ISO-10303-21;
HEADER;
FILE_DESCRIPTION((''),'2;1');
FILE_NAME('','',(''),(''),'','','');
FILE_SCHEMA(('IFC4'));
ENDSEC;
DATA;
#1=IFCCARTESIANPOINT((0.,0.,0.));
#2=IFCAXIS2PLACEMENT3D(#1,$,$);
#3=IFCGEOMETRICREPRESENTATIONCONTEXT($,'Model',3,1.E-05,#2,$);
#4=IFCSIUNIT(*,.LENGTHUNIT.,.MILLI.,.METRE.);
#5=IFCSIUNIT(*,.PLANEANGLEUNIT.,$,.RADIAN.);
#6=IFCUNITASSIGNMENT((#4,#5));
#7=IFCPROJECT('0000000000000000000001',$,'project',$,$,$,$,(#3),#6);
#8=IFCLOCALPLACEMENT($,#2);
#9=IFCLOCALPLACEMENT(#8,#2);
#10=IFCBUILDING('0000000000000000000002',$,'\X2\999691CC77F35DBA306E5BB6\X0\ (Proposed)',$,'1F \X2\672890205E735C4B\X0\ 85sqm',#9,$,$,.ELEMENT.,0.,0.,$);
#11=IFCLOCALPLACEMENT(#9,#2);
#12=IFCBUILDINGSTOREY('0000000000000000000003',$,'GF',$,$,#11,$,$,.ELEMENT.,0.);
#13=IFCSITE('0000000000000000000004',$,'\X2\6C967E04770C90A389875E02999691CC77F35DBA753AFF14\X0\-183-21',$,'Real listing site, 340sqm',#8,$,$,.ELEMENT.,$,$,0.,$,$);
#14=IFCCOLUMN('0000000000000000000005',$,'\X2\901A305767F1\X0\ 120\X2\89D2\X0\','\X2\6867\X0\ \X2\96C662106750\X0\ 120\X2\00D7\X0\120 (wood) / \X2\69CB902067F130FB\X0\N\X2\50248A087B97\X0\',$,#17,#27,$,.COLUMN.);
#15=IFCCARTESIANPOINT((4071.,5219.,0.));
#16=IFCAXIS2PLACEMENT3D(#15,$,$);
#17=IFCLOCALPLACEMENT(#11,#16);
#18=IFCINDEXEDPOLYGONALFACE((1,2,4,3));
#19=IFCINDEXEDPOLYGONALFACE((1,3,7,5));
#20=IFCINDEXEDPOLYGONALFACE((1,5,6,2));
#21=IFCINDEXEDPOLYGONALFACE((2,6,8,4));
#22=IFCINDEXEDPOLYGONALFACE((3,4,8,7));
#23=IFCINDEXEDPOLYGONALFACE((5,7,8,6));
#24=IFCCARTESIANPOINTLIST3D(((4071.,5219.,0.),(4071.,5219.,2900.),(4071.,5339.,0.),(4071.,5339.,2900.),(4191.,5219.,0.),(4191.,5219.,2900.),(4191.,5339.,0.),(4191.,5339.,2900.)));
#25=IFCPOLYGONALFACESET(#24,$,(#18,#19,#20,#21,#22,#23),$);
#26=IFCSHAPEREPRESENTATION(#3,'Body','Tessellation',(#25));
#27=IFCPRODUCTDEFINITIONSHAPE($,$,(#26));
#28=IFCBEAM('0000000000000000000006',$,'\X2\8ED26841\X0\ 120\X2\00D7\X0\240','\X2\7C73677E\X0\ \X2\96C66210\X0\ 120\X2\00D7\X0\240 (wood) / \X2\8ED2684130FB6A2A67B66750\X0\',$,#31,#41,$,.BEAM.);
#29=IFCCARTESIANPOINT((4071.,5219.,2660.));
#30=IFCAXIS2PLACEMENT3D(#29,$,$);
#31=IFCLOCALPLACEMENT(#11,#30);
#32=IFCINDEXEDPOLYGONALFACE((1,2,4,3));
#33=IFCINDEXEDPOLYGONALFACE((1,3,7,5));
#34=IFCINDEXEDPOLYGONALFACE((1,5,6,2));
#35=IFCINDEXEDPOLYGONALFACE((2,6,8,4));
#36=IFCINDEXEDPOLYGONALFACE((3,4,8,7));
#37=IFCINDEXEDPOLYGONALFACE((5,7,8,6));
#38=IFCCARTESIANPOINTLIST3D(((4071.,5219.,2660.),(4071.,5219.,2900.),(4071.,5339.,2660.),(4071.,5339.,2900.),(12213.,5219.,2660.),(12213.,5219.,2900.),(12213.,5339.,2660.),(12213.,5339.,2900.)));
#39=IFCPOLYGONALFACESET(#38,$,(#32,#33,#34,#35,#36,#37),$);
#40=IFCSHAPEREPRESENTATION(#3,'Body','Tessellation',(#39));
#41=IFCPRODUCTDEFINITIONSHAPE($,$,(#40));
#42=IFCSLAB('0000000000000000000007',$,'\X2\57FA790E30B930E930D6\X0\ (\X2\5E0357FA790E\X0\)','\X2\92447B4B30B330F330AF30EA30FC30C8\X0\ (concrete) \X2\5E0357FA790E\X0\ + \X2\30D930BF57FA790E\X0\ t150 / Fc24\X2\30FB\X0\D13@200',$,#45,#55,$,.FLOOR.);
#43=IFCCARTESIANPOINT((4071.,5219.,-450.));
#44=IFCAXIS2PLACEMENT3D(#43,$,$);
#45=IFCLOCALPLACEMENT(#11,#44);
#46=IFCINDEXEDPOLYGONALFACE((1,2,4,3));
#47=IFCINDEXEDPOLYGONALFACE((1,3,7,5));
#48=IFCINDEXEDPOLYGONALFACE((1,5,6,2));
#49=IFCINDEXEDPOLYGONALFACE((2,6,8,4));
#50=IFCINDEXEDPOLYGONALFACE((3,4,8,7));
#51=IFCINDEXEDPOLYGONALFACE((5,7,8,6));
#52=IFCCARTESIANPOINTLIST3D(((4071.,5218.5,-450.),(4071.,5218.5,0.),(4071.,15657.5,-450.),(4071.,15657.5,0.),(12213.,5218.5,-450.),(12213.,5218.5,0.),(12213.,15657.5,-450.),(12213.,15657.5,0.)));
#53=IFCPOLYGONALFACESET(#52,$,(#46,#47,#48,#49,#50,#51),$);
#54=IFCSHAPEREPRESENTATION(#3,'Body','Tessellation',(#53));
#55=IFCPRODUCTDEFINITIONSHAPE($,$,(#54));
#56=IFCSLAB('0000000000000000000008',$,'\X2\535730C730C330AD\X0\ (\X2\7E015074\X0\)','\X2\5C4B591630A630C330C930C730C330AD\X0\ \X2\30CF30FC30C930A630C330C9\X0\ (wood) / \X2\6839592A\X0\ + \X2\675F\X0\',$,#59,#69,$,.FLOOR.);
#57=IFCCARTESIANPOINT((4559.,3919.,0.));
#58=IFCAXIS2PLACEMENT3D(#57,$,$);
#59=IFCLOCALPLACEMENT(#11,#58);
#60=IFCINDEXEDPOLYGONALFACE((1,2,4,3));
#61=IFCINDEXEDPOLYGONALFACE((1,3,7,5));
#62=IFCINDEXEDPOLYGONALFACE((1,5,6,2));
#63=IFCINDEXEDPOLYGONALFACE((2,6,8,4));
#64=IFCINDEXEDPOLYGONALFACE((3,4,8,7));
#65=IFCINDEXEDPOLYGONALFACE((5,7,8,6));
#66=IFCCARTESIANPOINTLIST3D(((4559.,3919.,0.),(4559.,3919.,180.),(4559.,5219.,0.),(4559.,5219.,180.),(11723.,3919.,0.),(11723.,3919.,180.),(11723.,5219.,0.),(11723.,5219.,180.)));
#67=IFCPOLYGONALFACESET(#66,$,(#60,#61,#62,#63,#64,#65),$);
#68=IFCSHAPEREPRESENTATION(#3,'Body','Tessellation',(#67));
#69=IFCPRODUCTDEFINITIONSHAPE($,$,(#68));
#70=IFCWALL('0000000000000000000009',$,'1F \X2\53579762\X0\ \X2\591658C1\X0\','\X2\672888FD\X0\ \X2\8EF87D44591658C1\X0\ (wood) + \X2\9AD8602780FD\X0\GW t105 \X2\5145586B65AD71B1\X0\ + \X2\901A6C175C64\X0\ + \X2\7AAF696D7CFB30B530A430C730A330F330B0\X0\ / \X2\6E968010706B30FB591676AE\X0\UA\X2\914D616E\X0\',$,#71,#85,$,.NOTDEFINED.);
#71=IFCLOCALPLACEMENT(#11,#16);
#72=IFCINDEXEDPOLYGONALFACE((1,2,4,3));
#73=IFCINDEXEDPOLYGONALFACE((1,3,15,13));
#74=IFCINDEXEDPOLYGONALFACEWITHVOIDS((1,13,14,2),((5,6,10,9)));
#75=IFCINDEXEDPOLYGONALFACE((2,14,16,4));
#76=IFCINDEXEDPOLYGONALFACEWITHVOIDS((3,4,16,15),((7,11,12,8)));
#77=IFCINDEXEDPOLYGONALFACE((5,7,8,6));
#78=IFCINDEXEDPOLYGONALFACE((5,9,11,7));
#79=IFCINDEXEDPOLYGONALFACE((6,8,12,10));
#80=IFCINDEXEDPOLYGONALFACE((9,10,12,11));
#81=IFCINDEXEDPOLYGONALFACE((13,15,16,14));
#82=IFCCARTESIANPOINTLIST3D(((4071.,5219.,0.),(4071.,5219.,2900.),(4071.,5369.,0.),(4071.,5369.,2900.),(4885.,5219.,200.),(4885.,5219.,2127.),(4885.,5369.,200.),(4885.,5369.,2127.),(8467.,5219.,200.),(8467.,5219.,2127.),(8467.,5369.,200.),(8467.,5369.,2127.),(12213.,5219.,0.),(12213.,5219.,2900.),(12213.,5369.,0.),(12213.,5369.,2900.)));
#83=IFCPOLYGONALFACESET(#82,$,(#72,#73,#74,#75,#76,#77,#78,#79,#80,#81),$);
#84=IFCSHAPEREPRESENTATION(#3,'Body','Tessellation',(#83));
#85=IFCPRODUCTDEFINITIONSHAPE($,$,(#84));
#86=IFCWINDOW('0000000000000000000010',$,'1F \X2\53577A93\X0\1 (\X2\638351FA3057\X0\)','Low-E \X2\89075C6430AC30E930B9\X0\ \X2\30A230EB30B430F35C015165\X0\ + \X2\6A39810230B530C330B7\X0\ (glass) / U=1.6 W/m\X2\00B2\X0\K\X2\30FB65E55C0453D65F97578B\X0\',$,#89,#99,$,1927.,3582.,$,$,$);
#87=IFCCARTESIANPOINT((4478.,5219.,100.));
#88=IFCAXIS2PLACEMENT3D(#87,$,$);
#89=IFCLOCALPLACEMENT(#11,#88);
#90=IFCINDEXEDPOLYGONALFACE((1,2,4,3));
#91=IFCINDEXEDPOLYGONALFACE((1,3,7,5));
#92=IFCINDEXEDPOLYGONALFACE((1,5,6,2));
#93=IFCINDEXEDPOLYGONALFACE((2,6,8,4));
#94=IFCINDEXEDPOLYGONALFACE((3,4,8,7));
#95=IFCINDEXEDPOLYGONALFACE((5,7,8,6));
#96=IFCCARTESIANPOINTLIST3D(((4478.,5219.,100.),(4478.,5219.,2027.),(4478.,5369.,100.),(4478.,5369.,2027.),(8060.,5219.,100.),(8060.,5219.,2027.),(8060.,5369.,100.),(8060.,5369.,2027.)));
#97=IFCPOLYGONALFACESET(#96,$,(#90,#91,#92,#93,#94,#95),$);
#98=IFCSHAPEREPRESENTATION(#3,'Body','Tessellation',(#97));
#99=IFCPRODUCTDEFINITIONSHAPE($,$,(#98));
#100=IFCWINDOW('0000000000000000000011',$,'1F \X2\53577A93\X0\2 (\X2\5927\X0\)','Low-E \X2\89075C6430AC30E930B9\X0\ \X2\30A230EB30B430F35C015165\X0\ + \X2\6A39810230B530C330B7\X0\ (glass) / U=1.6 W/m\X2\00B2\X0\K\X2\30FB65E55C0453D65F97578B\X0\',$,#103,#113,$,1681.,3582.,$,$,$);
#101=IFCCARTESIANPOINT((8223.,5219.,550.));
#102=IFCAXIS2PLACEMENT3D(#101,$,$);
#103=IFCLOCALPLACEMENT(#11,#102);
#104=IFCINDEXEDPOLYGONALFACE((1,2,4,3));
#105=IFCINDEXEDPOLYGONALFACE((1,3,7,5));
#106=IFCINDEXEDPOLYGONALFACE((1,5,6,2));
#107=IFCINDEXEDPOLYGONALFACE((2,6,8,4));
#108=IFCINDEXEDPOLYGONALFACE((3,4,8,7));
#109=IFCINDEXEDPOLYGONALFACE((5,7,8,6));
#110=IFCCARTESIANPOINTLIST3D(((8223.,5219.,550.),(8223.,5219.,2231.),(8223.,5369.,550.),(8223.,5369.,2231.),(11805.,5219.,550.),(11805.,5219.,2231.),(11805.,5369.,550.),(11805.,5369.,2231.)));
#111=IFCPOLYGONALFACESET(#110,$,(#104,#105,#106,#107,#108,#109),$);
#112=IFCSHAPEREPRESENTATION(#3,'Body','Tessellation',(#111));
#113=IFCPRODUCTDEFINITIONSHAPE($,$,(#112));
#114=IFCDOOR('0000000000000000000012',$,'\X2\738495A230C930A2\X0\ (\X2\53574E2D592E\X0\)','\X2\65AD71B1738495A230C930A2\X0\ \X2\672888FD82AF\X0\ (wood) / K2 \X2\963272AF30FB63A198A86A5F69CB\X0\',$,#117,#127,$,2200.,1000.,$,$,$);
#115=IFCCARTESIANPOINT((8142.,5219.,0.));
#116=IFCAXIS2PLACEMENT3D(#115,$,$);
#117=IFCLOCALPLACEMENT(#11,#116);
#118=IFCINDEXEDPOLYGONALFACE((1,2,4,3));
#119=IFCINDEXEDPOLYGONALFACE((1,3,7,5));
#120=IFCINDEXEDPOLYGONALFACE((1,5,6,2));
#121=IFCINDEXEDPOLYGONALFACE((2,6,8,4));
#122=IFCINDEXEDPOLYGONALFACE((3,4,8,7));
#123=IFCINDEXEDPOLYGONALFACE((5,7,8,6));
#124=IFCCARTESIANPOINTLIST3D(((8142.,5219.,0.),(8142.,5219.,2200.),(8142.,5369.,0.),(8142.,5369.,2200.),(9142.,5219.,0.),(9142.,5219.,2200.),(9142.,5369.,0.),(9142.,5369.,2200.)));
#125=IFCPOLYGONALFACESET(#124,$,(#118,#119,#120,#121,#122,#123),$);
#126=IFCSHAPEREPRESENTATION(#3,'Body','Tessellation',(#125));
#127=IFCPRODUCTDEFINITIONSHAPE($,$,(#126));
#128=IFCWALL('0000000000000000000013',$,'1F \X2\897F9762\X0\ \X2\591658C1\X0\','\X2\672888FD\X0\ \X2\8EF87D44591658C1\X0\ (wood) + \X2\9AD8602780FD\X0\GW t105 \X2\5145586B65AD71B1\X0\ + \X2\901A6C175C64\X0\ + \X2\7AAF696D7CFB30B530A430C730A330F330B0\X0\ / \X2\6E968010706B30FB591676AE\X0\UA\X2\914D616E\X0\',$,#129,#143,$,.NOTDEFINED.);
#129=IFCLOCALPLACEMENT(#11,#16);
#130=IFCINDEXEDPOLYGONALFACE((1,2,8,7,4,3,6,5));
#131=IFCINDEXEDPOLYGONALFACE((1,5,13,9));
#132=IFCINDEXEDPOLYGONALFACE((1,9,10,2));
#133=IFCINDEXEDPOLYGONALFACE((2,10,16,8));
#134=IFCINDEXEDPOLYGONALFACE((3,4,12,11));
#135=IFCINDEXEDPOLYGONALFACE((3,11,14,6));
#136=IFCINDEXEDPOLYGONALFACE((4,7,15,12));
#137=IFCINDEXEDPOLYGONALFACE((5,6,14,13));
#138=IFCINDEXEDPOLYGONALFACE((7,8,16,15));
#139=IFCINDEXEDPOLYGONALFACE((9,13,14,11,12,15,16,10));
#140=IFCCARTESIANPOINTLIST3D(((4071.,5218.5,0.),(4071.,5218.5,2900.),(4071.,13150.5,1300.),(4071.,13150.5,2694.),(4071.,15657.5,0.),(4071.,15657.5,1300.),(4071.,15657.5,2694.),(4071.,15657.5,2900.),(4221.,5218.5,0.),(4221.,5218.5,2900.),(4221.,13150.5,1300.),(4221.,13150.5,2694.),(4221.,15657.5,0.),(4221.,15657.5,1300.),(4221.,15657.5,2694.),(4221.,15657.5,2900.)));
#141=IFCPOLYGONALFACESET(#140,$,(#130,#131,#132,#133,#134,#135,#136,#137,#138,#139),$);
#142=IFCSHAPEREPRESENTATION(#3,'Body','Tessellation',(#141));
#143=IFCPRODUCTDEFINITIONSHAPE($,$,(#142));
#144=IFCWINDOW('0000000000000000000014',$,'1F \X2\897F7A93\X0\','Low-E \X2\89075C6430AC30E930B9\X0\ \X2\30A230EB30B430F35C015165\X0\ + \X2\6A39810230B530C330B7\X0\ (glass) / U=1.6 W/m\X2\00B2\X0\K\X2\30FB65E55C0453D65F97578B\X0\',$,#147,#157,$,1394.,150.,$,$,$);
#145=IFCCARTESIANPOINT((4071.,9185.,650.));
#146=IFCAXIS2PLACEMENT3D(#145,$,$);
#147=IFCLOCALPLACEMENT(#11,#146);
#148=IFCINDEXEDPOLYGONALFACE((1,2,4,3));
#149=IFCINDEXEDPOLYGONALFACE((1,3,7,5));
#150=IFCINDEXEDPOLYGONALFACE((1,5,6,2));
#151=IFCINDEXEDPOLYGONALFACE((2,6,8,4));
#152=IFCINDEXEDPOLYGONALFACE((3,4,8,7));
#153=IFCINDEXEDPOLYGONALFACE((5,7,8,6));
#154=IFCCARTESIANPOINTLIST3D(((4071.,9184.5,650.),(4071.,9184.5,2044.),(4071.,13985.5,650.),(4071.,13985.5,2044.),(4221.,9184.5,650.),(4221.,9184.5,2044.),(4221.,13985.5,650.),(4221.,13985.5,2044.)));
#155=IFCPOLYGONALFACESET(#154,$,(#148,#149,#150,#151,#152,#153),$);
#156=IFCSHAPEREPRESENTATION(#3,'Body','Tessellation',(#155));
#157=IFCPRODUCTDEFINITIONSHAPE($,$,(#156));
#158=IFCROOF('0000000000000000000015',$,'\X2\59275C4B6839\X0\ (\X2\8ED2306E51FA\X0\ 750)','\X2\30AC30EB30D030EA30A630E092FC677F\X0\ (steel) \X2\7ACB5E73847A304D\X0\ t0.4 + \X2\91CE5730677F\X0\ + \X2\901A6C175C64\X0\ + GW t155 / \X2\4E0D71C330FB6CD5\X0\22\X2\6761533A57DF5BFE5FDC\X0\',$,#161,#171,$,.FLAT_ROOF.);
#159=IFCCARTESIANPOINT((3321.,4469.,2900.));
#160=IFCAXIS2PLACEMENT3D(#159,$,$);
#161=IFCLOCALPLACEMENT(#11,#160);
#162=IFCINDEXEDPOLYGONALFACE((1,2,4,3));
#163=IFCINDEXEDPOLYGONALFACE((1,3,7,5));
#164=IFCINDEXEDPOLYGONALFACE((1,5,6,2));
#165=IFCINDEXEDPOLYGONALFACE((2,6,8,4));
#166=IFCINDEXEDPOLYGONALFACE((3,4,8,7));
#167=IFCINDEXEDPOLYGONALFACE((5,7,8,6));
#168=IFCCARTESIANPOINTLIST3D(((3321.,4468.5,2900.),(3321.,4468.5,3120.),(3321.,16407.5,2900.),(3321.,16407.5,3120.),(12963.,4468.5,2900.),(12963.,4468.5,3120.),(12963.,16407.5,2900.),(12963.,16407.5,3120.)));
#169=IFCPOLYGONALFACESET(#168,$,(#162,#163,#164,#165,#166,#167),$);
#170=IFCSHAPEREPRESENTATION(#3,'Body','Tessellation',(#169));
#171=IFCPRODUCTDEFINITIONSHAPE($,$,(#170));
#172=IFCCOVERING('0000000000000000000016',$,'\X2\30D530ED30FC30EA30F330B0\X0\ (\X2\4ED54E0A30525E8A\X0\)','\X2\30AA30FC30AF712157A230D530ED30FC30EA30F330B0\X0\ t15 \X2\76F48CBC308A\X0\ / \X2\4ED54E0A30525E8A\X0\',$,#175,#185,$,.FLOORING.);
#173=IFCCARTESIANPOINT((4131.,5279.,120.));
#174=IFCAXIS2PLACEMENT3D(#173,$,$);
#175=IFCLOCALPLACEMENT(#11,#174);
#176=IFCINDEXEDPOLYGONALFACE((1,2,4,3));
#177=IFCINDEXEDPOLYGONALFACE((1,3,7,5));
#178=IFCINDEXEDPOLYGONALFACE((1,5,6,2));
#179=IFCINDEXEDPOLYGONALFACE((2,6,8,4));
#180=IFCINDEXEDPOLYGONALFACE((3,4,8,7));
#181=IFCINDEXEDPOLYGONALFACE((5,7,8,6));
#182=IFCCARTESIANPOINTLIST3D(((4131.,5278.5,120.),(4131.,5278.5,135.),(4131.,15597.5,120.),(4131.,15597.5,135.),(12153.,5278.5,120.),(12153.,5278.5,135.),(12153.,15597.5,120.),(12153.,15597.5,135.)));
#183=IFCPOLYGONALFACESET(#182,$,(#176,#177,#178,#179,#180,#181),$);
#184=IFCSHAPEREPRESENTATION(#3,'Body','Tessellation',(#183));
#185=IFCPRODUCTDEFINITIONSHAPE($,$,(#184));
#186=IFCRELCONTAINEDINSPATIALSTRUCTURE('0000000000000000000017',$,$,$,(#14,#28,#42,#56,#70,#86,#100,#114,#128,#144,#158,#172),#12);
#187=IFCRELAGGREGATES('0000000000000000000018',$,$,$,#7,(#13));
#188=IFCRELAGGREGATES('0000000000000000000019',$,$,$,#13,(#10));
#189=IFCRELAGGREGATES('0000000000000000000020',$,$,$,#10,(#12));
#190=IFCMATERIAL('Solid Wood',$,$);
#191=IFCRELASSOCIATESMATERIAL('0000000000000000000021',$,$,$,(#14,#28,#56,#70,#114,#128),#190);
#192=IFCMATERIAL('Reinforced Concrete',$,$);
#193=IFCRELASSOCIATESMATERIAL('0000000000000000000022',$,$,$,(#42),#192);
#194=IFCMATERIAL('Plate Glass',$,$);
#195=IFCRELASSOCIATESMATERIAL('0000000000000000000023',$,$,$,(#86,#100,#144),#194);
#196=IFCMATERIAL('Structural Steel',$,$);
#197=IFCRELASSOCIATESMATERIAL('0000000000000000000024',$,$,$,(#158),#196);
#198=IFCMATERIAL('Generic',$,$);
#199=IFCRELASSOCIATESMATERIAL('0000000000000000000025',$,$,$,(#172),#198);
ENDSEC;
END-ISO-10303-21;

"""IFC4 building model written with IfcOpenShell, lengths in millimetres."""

from ifc_helpers import new_model, si_unit, frame, frame_2d, origin, place, context, project, spatial, rectangle, extrude, material, element, fill, save


model = new_model("IFC4")

# Units and contexts
model_context = context("Model", 3, precision=1e-05, world=origin())
ifc_project = project(units=[si_unit("LENGTHUNIT", "METRE", prefix="MILLI"), si_unit("PLANEANGLEUNIT", "RADIAN")], contexts=[model_context])

# Site, building, storey
site_placement = place(None, origin())
site = spatial("IfcSite", under=ifc_project, at=site_placement, Name="沖縄県那覇市首里石嶺町４-183-21", ObjectType="Real listing site, 340sqm", CompositionType="ELEMENT", RefElevation=0.0)
building_placement = place(site_placement, origin())
building = spatial("IfcBuilding", under=site, at=building_placement, Name="首里石嶺の家 (Proposed)", ObjectType="1F 木造平屋 85sqm", CompositionType="ELEMENT", ElevationOfRefHeight=0.0, ElevationOfTerrain=0.0)
storey_placement = place(building_placement, origin())
storey = spatial("IfcBuildingStorey", under=building, at=storey_placement, Name="GF", CompositionType="ELEMENT", Elevation=0.0)

# Column
ifc_material_1 = material(Name="Solid Wood")
column_1_placement = place(storey_placement, frame((4071.0, 5219.0, 0.0)))
element("IfcColumn", 1, at=column_1_placement, inside=storey, material=ifc_material_1, Name="通し柱 120角", Description="桧 集成材 120×120 (wood) / 構造柱・N値計算", PredefinedType="COLUMN", context=model_context, shape_type="SweptSolid", body=[
    extrude(rectangle(XDim=120.0, YDim=120.0, at=frame_2d((60.0, 60.0))), frame((4071.0, 5219.0, 0.0)), (0.0, 0.0, 1.0), 2900.0),
])

# Beam
beam_1_placement = place(storey_placement, frame((4071.0, 5219.0, 2660.0)))
element("IfcBeam", 2, at=beam_1_placement, inside=storey, material=ifc_material_1, Name="軒桁 120×240", Description="米松 集成 120×240 (wood) / 軒桁・横架材", PredefinedType="BEAM", context=model_context, shape_type="SweptSolid", body=[
    extrude(rectangle(XDim=8142.0, YDim=120.0, at=frame_2d((4071.0, 60.0))), frame((4071.0, 5219.0, 2660.0)), (0.0, 0.0, 1.0), 240.0),
])

# Slabs
ifc_material_2 = material(Name="Reinforced Concrete")
slab_1_placement = place(storey_placement, frame((4071.0, 5219.0, -450.0)))
element("IfcSlab", 3, at=slab_1_placement, inside=storey, material=ifc_material_2, Name="基礎スラブ (布基礎)", Description="鉄筋コンクリート (concrete) 布基礎 + ベタ基礎 t150 / Fc24・D13@200", PredefinedType="FLOOR", context=model_context, shape_type="SweptSolid", body=[
    extrude(rectangle(XDim=8142.0, YDim=10439.0, at=frame_2d((4071.0, 5219.0))), frame((4071.0, 5219.0, -450.0)), (0.0, 0.0, 1.0), 450.0),
])
slab_2_placement = place(storey_placement, frame((4559.0, 3919.0, 0.0)))
element("IfcSlab", 4, at=slab_2_placement, inside=storey, material=ifc_material_1, Name="南デッキ (縁側)", Description="屋外ウッドデッキ ハードウッド (wood) / 根太 + 束", PredefinedType="FLOOR", context=model_context, shape_type="SweptSolid", body=[
    extrude(rectangle(XDim=7164.0, YDim=1300.0, at=frame_2d((3582.0, 650.0))), frame((4559.0, 3919.0, 0.0)), (0.0, 0.0, 1.0), 180.0),
])

# Wall, openings, windows, door
wall_1_placement = place(storey_placement, frame((4071.0, 5219.0, 0.0)))
wall_1 = element("IfcWall", 5, at=wall_1_placement, inside=storey, material=ifc_material_1, Name="1F 南面 外壁", Description="木製 軸組外壁 (wood) + 高性能GW t105 充填断熱 + 通気層 + 窯業系サイディング / 準耐火・外皮UA配慮", PredefinedType="NOTDEFINED", context=model_context, shape_type="SweptSolid", body=[
    extrude(rectangle(XDim=8142.0, YDim=150.0, at=frame_2d((4071.0, 75.0))), frame((4071.0, 5219.0, 0.0)), (0.0, 0.0, 1.0), 2900.0),
])
opening_1_placement = place(storey_placement, frame((4478.0, 5219.0, 100.0)))
opening_1 = element("IfcOpeningElement", 6, at=opening_1_placement, cuts=wall_1, PredefinedType="NOTDEFINED", context=model_context, shape_type="SweptSolid", body=[
    extrude(rectangle(XDim=3582.0, YDim=150.0, at=frame_2d((1791.0, 75.0))), frame((4478.0, 5219.0, 100.0)), (0.0, 0.0, 1.0), 1927.0),
])
opening_2_placement = place(storey_placement, frame((8223.0, 5219.0, 550.0)))
opening_2 = element("IfcOpeningElement", 7, at=opening_2_placement, cuts=wall_1, PredefinedType="NOTDEFINED", context=model_context, shape_type="SweptSolid", body=[
    extrude(rectangle(XDim=3582.0, YDim=150.0, at=frame_2d((1791.0, 75.0))), frame((8223.0, 5219.0, 550.0)), (0.0, 0.0, 1.0), 1681.0),
])
opening_3_placement = place(storey_placement, frame((8142.0, 5219.0, 0.0)))
opening_3 = element("IfcOpeningElement", 8, at=opening_3_placement, cuts=wall_1, PredefinedType="NOTDEFINED", context=model_context, shape_type="SweptSolid", body=[
    extrude(rectangle(XDim=1000.0, YDim=150.0, at=frame_2d((500.0, 75.0))), frame((8142.0, 5219.0, 0.0)), (0.0, 0.0, 1.0), 2200.0),
])
ifc_material_3 = material(Name="Plate Glass")
window_1_placement = place(storey_placement, frame((4478.0, 5219.0, 100.0)))
window_1 = element("IfcWindow", 9, at=window_1_placement, inside=storey, material=ifc_material_3, Name="1F 南窓1 (掃出し)", Description="Low-E 複層ガラス アルゴン封入 + 樹脂サッシ (glass) / U=1.6 W/m²K・日射取得型", OverallHeight=1927.0, OverallWidth=3582.0, context=model_context, shape_type="SweptSolid", body=[
    extrude(rectangle(XDim=3582.0, YDim=150.0, at=frame_2d((1791.0, 75.0))), frame((4478.0, 5219.0, 100.0)), (0.0, 0.0, 1.0), 1927.0),
])
fill(opening_1, window_1)
window_2_placement = place(storey_placement, frame((8223.0, 5219.0, 550.0)))
window_2 = element("IfcWindow", 10, at=window_2_placement, inside=storey, material=ifc_material_3, Name="1F 南窓2 (大)", Description="Low-E 複層ガラス アルゴン封入 + 樹脂サッシ (glass) / U=1.6 W/m²K・日射取得型", OverallHeight=1681.0, OverallWidth=3582.0, context=model_context, shape_type="SweptSolid", body=[
    extrude(rectangle(XDim=3582.0, YDim=150.0, at=frame_2d((1791.0, 75.0))), frame((8223.0, 5219.0, 550.0)), (0.0, 0.0, 1.0), 1681.0),
])
fill(opening_2, window_2)
door_placement = place(storey_placement, frame((8142.0, 5219.0, 0.0)))
door = element("IfcDoor", 11, at=door_placement, inside=storey, material=ifc_material_1, Name="玄関ドア (南中央)", Description="断熱玄関ドア 木製芯 (wood) / K2 防犯・採風機構", OverallHeight=2200.0, OverallWidth=1000.0, context=model_context, shape_type="SweptSolid", body=[
    extrude(rectangle(XDim=1000.0, YDim=150.0, at=frame_2d((500.0, 75.0))), frame((8142.0, 5219.0, 0.0)), (0.0, 0.0, 1.0), 2200.0),
])
fill(opening_3, door)

# Wall, opening, window
wall_2_placement = place(storey_placement, frame((4071.0, 5219.0, 0.0)))
wall_2 = element("IfcWall", 12, at=wall_2_placement, inside=storey, material=ifc_material_1, Name="1F 西面 外壁", Description="木製 軸組外壁 (wood) + 高性能GW t105 充填断熱 + 通気層 + 窯業系サイディング / 準耐火・外皮UA配慮", PredefinedType="NOTDEFINED", context=model_context, shape_type="SweptSolid", body=[
    extrude(rectangle(XDim=150.0, YDim=10439.0, at=frame_2d((75.0, 5219.0))), frame((4071.0, 5219.0, 0.0)), (0.0, 0.0, 1.0), 2900.0),
])
opening_4_placement = place(storey_placement, frame((4071.0, 9185.0, 650.0)))
opening_4 = element("IfcOpeningElement", 13, at=opening_4_placement, cuts=wall_2, PredefinedType="NOTDEFINED", context=model_context, shape_type="SweptSolid", body=[
    extrude(rectangle(XDim=150.0, YDim=4801.0, at=frame_2d((75.0, 2400.0))), frame((4071.0, 9185.0, 650.0)), (0.0, 0.0, 1.0), 1394.0),
])
window_3_placement = place(storey_placement, frame((4071.0, 9185.0, 650.0)))
window_3 = element("IfcWindow", 14, at=window_3_placement, inside=storey, material=ifc_material_3, Name="1F 西窓", Description="Low-E 複層ガラス アルゴン封入 + 樹脂サッシ (glass) / U=1.6 W/m²K・日射取得型", OverallHeight=1394.0, OverallWidth=150.0, context=model_context, shape_type="SweptSolid", body=[
    extrude(rectangle(XDim=150.0, YDim=4801.0, at=frame_2d((75.0, 2400.0))), frame((4071.0, 9185.0, 650.0)), (0.0, 0.0, 1.0), 1394.0),
])
fill(opening_4, window_3)

# Roof
ifc_material_4 = material(Name="Structural Steel")
roof_placement = place(storey_placement, frame((3321.0, 4469.0, 2900.0)))
element("IfcRoof", 15, at=roof_placement, inside=storey, material=ifc_material_4, Name="大屋根 (軒の出 750)", Description="ガルバリウム鋼板 (steel) 立平葺き t0.4 + 野地板 + 通気層 + GW t155 / 不燃・法22条区域対応", PredefinedType="FLAT_ROOF", context=model_context, shape_type="SweptSolid", body=[
    extrude(rectangle(XDim=9642.0, YDim=11939.0, at=frame_2d((4821.0, 5969.0))), frame((3321.0, 4469.0, 2900.0)), (0.0, 0.0, 1.0), 220.0),
])

# Covering
ifc_material_5 = material(Name="Generic")
covering_1_placement = place(storey_placement, frame((4131.0, 5279.0, 120.0)))
element("IfcCovering", 16, at=covering_1_placement, inside=storey, material=ifc_material_5, Name="フローリング (仕上げ床)", Description="オーク無垢フローリング t15 直貼り / 仕上げ床", PredefinedType="FLOORING", context=model_context, shape_type="SweptSolid", body=[
    extrude(rectangle(XDim=8022.0, YDim=10319.0, at=frame_2d((4011.0, 5159.0))), frame((4131.0, 5279.0, 120.0)), (0.0, 0.0, 1.0), 15.0),
])

save(model, "model.ifc")
